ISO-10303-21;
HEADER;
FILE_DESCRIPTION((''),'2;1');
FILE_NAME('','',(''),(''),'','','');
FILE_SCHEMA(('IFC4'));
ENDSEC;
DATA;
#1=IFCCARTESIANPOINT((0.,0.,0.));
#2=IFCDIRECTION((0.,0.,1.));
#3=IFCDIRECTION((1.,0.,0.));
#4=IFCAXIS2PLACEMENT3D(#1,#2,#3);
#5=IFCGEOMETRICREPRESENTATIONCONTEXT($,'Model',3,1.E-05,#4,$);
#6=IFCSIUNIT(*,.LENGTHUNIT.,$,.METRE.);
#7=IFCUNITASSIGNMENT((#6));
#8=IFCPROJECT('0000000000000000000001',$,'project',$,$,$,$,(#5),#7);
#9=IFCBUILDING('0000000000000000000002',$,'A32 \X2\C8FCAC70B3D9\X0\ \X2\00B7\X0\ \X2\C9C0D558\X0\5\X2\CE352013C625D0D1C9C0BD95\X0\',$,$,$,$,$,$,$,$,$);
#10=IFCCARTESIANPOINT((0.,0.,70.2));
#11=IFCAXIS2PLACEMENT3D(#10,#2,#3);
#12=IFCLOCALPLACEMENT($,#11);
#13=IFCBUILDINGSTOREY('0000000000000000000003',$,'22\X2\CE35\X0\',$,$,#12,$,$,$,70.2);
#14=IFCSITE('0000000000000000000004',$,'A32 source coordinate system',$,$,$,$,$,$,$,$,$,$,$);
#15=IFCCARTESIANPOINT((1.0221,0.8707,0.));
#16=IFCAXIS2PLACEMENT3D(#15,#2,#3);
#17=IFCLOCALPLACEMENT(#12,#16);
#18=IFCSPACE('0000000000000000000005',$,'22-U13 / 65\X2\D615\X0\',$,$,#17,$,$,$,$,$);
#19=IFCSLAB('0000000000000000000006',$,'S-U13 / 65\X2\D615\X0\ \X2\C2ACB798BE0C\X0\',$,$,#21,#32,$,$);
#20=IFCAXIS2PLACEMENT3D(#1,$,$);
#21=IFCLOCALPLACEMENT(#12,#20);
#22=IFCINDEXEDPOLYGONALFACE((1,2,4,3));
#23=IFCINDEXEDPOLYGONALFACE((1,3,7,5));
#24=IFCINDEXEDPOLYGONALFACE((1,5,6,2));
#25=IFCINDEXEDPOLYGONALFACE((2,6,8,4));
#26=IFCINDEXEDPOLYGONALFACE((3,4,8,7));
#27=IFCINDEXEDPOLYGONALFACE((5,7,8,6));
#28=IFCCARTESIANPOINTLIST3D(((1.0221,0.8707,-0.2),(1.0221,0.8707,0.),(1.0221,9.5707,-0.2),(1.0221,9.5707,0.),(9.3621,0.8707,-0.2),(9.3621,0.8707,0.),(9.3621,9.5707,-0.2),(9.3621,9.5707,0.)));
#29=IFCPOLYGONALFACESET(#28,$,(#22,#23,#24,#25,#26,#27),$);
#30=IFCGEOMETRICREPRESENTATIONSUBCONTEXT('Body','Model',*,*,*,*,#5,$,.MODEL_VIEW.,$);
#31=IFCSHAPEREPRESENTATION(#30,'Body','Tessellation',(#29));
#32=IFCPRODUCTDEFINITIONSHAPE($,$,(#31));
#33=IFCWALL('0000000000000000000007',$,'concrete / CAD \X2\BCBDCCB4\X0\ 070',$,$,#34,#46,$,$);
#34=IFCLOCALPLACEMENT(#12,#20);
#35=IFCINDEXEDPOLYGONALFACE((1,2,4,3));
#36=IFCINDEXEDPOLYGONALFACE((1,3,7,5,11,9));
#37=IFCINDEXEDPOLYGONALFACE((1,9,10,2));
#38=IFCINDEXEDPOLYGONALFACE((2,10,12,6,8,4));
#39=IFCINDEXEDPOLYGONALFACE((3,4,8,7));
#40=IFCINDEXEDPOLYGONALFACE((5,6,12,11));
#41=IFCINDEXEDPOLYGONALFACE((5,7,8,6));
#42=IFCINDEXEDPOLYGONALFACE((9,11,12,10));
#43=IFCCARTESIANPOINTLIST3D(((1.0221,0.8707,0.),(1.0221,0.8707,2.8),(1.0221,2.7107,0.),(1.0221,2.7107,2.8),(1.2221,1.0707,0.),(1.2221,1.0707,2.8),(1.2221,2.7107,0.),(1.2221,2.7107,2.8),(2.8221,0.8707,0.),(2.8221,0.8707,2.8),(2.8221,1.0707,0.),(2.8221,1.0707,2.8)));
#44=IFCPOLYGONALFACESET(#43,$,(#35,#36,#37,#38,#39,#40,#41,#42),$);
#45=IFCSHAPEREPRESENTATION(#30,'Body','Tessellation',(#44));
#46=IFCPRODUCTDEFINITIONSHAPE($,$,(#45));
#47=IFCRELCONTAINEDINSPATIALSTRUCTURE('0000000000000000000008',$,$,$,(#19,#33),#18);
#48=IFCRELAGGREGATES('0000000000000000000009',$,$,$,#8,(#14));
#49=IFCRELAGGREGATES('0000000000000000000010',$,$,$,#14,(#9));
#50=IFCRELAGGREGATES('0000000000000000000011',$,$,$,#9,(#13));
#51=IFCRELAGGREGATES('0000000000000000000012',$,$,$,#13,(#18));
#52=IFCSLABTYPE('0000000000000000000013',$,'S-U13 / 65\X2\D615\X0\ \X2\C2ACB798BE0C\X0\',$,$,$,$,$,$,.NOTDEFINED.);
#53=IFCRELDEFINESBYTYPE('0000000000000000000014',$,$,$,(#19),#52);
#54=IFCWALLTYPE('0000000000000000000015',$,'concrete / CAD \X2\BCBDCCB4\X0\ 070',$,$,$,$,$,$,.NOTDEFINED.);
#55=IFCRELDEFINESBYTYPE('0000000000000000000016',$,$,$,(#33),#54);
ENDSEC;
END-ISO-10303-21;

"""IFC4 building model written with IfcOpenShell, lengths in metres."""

from ifc_helpers import new_model, si_unit, frame, origin, origin_with_axes, place, context, subcontext, project, spatial, polyline, outline, extrude, source, transform, mapped, type_object, type_shapes, element, save


model = new_model("IFC4")

# Units and contexts
model_context = context("Model", 3, precision=1e-05, world=origin_with_axes())
body_context = subcontext(model_context, "Body", "Model", "MODEL_VIEW")
ifc_project = project(units=[si_unit("LENGTHUNIT", "METRE")], contexts=[model_context])

# Site, building, storey, space
storey_placement = place(None, frame((0.0, 0.0, 70.2), z_axis=(0.0, 0.0, 1.0), x_axis=(1.0, 0.0, 0.0)))
space_placement = place(storey_placement, frame((1.0221, 0.8707, 0.0), z_axis=(0.0, 0.0, 1.0), x_axis=(1.0, 0.0, 0.0)))
site = spatial("IfcSite", under=ifc_project, Name="A32 source coordinate system")
building = spatial("IfcBuilding", under=site, Name="A32 주거동 · 지하5층–옥탑지붕")
storey = spatial("IfcBuildingStorey", under=building, at=storey_placement, Name="22층", Elevation=70.2)
space = spatial("IfcSpace", under=storey, at=space_placement, Name="22-U13 / 65형")

# Slab
slab_type = type_object("IfcSlabType", Name="S-U13 / 65형 슬래브", PredefinedType="NOTDEFINED")
shared_shape_1 = source(origin(), body_context, "Body", "SweptSolid", [
    extrude(outline(polyline([(0.0, 0.0), (0.0, 8.7), (8.34, 8.7), (8.34, 0.0), (0.0, 0.0)])), frame((0.0, 0.0, -0.2)), (0.0, 0.0, 1.0), 0.2),
])
type_shapes(slab_type, [shared_shape_1])
slab_placement = place(space_placement, origin_with_axes())
element("IfcSlab", 1, at=slab_placement, inside=space, type_object=slab_type, Name="S-U13 / 65형 슬래브", context=body_context, shape_type="MappedRepresentation", body=[
    mapped(shared_shape_1, transform((0.0, 0.0, 0.0), scale=1.0)),
])

# Wall
wall_type_1 = type_object("IfcWallType", Name="concrete / CAD 벽체 070", PredefinedType="NOTDEFINED")
shared_shape_2 = source(origin(), body_context, "Body", "SweptSolid", [
    extrude(outline(polyline([(0.2, 1.84), (0.2, 0.2), (1.8, 0.2), (1.8, 0.0), (0.0, 0.0), (0.0, 1.84), (0.2, 1.84)])), origin(), (0.0, 0.0, 1.0), 2.8),
])
type_shapes(wall_type_1, [shared_shape_2])
wall_1_placement = place(space_placement, origin_with_axes())
element("IfcWall", 2, at=wall_1_placement, inside=space, type_object=wall_type_1, Name="concrete / CAD 벽체 070", context=body_context, shape_type="MappedRepresentation", body=[
    mapped(shared_shape_2, transform((0.0, 0.0, 0.0), scale=1.0)),
])

save(model, "model.ifc")
